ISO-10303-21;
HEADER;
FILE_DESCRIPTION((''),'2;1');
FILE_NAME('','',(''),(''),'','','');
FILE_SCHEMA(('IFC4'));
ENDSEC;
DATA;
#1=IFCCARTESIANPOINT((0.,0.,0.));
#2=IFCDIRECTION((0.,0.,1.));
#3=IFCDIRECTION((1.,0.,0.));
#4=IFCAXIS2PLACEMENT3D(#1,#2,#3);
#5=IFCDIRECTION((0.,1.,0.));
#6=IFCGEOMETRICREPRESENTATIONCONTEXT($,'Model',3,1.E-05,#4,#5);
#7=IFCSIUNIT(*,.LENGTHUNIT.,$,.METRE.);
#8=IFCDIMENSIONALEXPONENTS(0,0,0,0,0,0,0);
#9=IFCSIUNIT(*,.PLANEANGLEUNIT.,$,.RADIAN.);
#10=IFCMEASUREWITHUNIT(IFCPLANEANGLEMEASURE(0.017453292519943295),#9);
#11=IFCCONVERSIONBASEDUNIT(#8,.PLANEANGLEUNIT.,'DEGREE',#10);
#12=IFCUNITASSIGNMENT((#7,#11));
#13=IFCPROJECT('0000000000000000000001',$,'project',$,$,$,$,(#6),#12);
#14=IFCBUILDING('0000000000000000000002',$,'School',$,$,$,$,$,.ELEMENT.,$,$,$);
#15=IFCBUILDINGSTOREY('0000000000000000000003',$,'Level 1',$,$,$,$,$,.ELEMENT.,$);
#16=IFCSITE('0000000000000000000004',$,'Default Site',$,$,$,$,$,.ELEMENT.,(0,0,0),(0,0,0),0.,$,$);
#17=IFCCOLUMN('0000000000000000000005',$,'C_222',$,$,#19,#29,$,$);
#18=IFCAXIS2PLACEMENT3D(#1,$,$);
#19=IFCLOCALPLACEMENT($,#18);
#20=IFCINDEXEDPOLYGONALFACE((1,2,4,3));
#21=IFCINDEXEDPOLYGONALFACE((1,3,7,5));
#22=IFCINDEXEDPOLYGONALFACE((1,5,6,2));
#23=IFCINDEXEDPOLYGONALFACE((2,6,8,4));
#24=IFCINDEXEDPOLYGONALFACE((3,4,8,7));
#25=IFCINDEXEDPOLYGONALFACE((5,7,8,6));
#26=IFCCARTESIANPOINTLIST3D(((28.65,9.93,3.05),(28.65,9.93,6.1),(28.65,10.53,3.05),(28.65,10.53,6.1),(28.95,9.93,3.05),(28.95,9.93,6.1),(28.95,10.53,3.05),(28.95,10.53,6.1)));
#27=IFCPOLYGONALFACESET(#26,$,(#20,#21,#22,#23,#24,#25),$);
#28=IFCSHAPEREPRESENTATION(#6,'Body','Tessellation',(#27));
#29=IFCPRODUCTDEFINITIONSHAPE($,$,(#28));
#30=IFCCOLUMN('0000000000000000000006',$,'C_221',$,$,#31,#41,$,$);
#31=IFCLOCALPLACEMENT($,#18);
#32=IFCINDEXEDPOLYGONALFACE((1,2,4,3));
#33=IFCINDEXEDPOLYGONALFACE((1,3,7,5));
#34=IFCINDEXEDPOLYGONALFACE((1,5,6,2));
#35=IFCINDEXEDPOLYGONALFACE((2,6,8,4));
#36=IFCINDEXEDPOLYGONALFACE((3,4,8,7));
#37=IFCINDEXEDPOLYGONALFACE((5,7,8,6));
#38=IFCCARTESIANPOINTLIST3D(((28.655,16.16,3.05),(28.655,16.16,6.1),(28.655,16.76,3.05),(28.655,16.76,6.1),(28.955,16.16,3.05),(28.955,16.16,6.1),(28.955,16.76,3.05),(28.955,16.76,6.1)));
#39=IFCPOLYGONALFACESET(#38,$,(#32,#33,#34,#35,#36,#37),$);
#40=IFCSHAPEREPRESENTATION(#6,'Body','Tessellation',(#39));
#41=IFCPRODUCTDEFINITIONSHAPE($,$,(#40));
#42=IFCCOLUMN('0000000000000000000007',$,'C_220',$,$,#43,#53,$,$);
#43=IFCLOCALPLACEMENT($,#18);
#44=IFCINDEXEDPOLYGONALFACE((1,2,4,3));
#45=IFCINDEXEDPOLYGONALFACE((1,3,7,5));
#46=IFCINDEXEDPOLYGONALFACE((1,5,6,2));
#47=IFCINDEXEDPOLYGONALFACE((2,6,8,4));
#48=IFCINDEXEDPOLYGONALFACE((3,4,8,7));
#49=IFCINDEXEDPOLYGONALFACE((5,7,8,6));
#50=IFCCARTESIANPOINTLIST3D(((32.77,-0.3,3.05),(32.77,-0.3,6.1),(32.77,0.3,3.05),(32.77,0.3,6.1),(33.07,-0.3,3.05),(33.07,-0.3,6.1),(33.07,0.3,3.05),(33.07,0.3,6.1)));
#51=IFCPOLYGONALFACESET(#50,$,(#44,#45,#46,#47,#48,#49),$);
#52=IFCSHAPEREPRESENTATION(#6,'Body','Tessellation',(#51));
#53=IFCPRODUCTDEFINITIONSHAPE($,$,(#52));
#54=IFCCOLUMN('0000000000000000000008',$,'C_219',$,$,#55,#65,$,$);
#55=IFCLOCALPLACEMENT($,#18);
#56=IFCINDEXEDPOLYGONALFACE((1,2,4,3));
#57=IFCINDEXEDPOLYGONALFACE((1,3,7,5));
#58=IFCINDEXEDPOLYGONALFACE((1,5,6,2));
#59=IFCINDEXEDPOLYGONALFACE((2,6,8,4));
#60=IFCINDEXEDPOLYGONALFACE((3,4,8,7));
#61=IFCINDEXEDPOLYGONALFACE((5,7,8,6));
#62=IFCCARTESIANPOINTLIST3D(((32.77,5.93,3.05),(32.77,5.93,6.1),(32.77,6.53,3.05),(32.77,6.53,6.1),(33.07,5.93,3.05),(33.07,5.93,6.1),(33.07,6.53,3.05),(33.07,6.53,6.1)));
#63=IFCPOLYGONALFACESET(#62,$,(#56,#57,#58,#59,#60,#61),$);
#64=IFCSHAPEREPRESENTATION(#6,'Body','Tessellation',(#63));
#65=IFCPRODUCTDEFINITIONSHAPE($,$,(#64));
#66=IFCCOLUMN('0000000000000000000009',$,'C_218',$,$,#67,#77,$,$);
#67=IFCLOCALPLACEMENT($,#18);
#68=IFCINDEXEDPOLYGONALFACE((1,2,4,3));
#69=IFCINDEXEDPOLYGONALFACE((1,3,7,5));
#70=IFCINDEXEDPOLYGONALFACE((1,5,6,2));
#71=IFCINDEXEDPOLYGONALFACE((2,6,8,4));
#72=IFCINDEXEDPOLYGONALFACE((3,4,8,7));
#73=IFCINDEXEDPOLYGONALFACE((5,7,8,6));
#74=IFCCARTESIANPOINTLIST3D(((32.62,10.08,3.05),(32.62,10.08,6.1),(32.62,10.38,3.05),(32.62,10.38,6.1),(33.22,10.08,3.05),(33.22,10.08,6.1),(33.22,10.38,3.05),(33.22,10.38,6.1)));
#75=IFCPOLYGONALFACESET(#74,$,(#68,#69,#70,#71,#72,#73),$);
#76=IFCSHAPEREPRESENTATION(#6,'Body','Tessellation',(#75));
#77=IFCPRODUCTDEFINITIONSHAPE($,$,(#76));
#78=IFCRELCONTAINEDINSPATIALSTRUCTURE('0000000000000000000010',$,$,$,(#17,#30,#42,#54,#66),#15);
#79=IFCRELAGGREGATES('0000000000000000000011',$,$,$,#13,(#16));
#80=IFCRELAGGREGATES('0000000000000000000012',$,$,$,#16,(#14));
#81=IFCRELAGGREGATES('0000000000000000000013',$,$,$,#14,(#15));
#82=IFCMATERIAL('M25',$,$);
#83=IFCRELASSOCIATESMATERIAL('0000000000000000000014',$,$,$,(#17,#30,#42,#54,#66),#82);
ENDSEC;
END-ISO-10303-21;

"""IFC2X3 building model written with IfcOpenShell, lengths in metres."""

from ifc_helpers import new_model, entity, si_unit, converted_unit, direction, frame, frame_2d, origin_with_axes, place, context, project, spatial, rectangle, extrude, material, element, save


model = new_model("IFC2X3")

# Units and contexts
model_context = context("Model", 3, precision=1e-05, world=origin_with_axes(), true_north=direction((0.0, 1.0, 0.0)))
ifc_project = project(units=[si_unit("LENGTHUNIT", "METRE"), converted_unit("PLANEANGLEUNIT", "DEGREE", entity("IfcPlaneAngleMeasure", 0.017453292519943295), si_unit("PLANEANGLEUNIT", "RADIAN"), dimensions=[0, 0, 0, 0, 0, 0, 0])], contexts=[model_context])

# Site, building, storey
site = spatial("IfcSite", under=ifc_project, Name="Default Site", CompositionType="ELEMENT", RefLatitude=(0, 0, 0), RefLongitude=(0, 0, 0), RefElevation=0.0)
building = spatial("IfcBuilding", under=site, Name="School", CompositionType="ELEMENT")
storey = spatial("IfcBuildingStorey", under=building, Name="Level 1", CompositionType="ELEMENT")

# Columns
ifc_material = material(Name="M25")
placement = place(None, origin_with_axes())
element("IfcColumn", 1, at=placement, inside=storey, material=ifc_material, Name="C_222", context=model_context, shape_type="SweptSolid", body=[
    extrude(rectangle(XDim=0.3, YDim=0.6, at=frame_2d((0.0, 0.0), x_axis=(1.0, 0.0, 0.0))), frame((28.8, 10.23, 3.05), z_axis=(0.0, 0.0, 1.0), x_axis=(1.0, 0.0, 0.0)), (0.0, 0.0, 1.0), 3.05),
])
element("IfcColumn", 2, at=placement, inside=storey, material=ifc_material, Name="C_221", context=model_context, shape_type="SweptSolid", body=[
    extrude(rectangle(XDim=0.3, YDim=0.6, at=frame_2d((0.0, 0.0), x_axis=(1.0, 0.0, 0.0))), frame((28.805, 16.46, 3.05), z_axis=(0.0, 0.0, 1.0), x_axis=(1.0, 0.0, 0.0)), (0.0, 0.0, 1.0), 3.05),
])
element("IfcColumn", 3, at=placement, inside=storey, material=ifc_material, Name="C_220", context=model_context, shape_type="SweptSolid", body=[
    extrude(rectangle(XDim=0.3, YDim=0.6, at=frame_2d((0.0, 0.0), x_axis=(1.0, 0.0, 0.0))), frame((32.92, 0.0, 3.05), z_axis=(0.0, 0.0, 1.0), x_axis=(1.0, 0.0, 0.0)), (0.0, 0.0, 1.0), 3.05),
])
element("IfcColumn", 4, at=placement, inside=storey, material=ifc_material, Name="C_219", context=model_context, shape_type="SweptSolid", body=[
    extrude(rectangle(XDim=0.3, YDim=0.6, at=frame_2d((0.0, 0.0), x_axis=(1.0, 0.0, 0.0))), frame((32.92, 6.23, 3.05), z_axis=(0.0, 0.0, 1.0), x_axis=(1.0, 0.0, 0.0)), (0.0, 0.0, 1.0), 3.05),
])
element("IfcColumn", 5, at=placement, inside=storey, material=ifc_material, Name="C_218", context=model_context, shape_type="SweptSolid", body=[
    extrude(rectangle(XDim=0.6, YDim=0.3, at=frame_2d((0.0, 0.0), x_axis=(1.0, 0.0, 0.0))), frame((32.92, 10.23, 3.05), z_axis=(0.0, 0.0, 1.0), x_axis=(1.0, 0.0, 0.0)), (0.0, 0.0, 1.0), 3.05),
])

save(model, "model.ifc")
